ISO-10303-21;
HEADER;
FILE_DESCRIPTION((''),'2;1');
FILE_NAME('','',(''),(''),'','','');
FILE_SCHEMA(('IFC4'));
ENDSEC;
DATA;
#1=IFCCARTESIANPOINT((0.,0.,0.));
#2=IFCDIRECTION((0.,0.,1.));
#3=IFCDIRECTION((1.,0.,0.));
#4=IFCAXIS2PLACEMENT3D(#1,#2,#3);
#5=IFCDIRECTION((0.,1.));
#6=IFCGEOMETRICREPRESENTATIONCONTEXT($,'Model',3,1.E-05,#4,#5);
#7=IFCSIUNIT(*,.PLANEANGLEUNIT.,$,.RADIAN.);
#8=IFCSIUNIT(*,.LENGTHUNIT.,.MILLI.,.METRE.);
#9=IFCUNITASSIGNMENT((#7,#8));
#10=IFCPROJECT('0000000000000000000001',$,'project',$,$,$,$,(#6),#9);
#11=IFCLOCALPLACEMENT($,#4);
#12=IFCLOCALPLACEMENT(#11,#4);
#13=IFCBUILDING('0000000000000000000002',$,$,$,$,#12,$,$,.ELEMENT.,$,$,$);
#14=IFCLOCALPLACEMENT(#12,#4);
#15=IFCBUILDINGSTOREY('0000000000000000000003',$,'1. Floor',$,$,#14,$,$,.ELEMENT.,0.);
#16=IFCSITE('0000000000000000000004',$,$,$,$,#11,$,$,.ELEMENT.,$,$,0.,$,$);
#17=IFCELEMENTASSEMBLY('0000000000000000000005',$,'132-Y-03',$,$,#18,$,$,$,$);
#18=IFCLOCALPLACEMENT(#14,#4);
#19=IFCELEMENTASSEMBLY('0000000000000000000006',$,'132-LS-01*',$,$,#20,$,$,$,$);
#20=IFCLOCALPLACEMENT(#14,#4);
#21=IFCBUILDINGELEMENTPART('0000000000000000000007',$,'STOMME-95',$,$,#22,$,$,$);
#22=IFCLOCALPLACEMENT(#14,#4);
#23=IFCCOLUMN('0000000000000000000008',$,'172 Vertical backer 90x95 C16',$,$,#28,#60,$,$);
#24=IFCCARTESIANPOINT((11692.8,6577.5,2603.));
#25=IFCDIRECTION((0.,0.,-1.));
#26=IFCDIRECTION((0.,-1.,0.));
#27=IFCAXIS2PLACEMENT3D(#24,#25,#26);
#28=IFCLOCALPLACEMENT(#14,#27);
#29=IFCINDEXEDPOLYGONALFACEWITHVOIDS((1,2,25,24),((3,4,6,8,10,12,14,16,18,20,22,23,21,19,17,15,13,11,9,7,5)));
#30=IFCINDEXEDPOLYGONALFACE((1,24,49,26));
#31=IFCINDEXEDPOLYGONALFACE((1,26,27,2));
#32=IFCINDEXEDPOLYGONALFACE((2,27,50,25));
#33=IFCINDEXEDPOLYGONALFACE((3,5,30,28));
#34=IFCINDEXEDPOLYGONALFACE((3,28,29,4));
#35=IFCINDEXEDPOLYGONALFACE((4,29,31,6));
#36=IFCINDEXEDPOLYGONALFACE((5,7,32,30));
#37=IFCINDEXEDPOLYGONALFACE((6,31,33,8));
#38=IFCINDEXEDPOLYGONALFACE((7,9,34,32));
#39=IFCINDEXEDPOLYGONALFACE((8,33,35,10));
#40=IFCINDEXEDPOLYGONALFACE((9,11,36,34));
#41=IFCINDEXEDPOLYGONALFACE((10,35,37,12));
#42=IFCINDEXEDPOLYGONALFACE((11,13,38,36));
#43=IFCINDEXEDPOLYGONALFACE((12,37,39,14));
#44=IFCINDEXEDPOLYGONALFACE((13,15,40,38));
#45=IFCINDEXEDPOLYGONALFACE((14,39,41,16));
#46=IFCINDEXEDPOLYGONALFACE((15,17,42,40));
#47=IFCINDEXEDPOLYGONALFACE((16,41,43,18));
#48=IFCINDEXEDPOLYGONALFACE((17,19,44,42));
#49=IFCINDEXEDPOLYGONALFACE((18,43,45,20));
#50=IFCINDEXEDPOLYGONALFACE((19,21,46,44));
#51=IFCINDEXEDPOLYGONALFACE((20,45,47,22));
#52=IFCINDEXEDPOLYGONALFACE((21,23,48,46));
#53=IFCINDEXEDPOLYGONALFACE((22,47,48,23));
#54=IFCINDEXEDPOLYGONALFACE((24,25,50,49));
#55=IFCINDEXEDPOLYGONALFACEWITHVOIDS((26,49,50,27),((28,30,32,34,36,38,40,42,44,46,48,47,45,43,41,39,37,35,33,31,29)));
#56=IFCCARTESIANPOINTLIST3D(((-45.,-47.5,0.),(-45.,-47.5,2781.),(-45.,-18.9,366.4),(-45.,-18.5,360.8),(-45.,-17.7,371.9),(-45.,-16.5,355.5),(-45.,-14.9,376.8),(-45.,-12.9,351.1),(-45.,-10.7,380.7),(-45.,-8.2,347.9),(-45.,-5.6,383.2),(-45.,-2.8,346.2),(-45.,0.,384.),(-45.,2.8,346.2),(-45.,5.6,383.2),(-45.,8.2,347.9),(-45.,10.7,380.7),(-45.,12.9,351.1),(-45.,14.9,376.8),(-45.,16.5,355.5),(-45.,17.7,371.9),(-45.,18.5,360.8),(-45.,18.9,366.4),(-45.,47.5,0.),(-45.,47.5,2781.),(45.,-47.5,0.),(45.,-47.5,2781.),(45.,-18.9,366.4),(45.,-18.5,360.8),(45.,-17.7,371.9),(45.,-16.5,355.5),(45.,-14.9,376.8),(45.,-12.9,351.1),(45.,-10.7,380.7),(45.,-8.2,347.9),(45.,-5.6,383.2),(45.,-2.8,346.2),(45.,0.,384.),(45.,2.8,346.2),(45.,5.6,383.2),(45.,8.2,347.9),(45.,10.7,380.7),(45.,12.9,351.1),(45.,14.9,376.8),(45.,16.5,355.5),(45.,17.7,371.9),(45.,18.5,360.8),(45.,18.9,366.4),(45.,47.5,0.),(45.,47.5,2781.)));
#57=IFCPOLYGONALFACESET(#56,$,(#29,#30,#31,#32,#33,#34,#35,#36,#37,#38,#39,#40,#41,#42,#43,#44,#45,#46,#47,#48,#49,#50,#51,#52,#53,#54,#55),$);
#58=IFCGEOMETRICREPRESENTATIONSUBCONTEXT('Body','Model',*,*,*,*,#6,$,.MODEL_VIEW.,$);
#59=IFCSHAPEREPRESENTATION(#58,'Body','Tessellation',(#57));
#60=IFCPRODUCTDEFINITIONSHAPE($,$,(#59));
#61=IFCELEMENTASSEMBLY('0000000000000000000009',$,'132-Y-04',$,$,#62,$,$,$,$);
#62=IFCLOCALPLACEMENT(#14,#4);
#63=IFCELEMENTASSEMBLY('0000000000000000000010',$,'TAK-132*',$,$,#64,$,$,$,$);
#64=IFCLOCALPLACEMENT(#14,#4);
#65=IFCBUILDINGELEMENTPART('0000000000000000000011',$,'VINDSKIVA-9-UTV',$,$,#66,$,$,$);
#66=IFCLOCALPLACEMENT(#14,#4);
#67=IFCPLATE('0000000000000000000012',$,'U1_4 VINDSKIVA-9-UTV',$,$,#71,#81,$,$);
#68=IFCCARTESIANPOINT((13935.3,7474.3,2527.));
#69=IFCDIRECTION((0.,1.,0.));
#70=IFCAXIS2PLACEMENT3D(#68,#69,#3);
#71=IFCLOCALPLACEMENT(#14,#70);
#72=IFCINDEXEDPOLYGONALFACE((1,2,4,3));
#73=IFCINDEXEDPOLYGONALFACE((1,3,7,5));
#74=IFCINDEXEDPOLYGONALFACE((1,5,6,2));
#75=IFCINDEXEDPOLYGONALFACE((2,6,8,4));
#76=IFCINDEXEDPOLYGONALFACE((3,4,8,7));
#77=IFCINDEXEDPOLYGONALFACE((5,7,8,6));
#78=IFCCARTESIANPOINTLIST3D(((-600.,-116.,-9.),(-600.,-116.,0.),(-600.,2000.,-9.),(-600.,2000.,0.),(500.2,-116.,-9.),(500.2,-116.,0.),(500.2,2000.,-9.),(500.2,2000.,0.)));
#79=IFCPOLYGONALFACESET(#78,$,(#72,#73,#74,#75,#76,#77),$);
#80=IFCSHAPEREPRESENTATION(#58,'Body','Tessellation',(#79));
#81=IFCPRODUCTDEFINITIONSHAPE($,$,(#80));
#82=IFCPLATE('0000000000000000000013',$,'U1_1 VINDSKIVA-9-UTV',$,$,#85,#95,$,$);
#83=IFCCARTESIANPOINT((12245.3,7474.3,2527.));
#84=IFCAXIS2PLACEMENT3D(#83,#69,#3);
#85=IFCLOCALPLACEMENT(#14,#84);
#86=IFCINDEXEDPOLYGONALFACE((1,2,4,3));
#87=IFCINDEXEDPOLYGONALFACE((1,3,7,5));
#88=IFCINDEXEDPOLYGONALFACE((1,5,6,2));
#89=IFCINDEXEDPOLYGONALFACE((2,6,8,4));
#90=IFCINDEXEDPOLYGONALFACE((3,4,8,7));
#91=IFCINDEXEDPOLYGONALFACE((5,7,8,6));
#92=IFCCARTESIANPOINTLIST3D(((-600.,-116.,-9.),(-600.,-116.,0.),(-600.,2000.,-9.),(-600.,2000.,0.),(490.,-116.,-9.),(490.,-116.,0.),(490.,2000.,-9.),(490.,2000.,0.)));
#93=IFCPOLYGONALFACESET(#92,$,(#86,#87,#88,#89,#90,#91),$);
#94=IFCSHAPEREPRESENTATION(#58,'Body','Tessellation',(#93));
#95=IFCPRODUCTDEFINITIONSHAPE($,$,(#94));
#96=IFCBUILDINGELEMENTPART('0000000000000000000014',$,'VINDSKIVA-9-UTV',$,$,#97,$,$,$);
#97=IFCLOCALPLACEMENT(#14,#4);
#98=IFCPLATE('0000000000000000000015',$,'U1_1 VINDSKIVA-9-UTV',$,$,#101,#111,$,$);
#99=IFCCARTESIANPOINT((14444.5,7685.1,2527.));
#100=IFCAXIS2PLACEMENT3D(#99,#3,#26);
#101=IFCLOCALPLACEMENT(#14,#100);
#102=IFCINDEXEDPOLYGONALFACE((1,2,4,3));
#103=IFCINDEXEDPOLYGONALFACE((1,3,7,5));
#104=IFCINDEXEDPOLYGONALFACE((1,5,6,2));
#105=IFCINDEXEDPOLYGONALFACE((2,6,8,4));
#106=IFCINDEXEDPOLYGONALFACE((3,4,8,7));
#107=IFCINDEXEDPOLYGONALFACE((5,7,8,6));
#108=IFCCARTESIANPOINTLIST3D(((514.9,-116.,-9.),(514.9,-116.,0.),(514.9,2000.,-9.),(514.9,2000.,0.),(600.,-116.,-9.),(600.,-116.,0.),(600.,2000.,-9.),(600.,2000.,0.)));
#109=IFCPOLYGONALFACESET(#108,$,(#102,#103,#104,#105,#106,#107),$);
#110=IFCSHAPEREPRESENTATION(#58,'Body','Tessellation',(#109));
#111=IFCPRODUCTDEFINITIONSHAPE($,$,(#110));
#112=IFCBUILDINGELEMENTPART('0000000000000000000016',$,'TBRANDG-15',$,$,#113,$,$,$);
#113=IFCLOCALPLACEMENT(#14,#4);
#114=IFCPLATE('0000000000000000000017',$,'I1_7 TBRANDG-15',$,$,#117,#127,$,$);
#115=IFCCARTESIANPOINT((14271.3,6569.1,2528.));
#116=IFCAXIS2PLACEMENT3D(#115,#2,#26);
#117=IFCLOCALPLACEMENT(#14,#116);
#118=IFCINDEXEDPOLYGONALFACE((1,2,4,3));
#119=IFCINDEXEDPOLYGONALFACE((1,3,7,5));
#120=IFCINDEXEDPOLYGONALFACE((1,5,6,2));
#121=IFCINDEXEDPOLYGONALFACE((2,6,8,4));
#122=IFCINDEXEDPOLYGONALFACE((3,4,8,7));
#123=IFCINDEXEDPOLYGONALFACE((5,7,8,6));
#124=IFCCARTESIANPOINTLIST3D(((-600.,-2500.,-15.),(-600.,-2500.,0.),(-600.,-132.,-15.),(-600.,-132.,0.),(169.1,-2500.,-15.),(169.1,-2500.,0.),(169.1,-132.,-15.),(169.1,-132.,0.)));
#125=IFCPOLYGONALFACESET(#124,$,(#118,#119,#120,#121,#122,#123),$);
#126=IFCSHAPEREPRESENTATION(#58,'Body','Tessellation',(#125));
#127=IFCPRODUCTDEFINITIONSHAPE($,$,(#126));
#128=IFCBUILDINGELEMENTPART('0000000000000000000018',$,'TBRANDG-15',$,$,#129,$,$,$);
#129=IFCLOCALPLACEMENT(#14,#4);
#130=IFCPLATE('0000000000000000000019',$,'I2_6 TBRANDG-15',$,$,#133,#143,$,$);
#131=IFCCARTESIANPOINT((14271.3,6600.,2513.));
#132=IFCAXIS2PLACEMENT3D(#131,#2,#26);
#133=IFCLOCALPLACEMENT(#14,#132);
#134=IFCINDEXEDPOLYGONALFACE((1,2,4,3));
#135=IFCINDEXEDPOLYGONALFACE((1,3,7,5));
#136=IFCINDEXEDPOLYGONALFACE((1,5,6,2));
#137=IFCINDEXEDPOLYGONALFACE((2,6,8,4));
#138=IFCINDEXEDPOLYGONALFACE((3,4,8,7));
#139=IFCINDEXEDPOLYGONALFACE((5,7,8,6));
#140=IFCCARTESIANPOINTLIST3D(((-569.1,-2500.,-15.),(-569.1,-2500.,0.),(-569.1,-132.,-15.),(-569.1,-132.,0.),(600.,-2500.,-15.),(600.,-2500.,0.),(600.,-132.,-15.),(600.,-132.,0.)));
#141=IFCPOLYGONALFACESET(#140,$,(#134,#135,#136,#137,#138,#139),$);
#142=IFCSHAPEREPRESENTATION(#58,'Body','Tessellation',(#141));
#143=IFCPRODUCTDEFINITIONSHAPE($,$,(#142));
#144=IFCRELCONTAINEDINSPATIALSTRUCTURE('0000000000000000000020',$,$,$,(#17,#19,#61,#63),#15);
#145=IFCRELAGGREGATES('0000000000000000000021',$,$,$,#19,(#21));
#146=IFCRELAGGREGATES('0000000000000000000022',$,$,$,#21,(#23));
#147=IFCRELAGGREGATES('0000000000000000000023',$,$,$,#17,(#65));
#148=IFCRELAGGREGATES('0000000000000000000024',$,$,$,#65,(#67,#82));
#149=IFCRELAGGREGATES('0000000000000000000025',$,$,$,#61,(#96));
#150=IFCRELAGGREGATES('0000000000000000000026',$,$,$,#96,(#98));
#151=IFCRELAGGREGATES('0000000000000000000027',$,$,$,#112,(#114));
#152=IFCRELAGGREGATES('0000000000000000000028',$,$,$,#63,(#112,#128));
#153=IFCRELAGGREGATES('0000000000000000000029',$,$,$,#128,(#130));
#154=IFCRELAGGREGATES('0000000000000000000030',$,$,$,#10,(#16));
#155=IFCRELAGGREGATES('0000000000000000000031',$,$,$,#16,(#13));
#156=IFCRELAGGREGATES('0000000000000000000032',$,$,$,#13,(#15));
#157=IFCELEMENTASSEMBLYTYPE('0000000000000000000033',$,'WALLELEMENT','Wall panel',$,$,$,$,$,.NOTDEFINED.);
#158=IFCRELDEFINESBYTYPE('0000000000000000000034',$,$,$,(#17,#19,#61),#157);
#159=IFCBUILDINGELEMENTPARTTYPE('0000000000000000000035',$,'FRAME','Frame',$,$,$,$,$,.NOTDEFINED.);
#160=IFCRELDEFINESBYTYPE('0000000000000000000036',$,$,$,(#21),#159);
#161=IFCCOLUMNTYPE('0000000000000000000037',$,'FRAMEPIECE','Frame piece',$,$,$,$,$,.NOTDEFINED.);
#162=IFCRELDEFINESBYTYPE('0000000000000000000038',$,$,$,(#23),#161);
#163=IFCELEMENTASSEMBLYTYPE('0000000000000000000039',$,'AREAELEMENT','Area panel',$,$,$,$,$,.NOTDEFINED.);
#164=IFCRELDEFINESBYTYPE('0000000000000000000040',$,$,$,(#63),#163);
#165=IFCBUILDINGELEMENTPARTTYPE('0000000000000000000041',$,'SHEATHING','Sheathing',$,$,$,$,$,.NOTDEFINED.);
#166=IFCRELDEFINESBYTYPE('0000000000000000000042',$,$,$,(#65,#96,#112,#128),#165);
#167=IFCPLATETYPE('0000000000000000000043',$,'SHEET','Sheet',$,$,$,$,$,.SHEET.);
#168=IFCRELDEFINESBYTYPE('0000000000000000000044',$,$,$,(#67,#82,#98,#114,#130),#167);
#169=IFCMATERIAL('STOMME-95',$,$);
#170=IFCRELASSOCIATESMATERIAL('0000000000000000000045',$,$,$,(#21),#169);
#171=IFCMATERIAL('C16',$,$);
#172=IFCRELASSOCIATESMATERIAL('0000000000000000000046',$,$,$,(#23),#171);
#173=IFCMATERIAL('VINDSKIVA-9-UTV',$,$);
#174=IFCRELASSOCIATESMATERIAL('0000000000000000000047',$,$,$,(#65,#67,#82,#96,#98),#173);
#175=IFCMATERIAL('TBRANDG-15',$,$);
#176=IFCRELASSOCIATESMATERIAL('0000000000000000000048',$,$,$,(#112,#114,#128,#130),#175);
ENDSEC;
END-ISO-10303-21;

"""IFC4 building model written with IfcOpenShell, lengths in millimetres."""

from ifc_helpers import new_model, si_unit, direction, frame, origin_with_axes, origin_2d_with_axis, place, context, subcontext, project, spatial, rectangle, circle, extrude, boolean, material, type_object, element, aggregate, save


model = new_model("IFC4")

# Units and contexts
model_context = context("Model", 3, precision=1e-05, world=origin_with_axes(), true_north=direction((0.0, 1.0)))
body_context = subcontext(model_context, "Body", "Model", "MODEL_VIEW")
ifc_project = project(units=[si_unit("PLANEANGLEUNIT", "RADIAN"), si_unit("LENGTHUNIT", "METRE", prefix="MILLI")], contexts=[model_context])

# Site, building, storey
site_placement = place(None, origin_with_axes())
site = spatial("IfcSite", under=ifc_project, at=site_placement, CompositionType="ELEMENT", RefElevation=0.0)
building_placement = place(site_placement, origin_with_axes())
building = spatial("IfcBuilding", under=site, at=building_placement, CompositionType="ELEMENT")
storey_placement = place(building_placement, origin_with_axes())
storey = spatial("IfcBuildingStorey", under=building, at=storey_placement, Name="1. Floor", CompositionType="ELEMENT", Elevation=0.0)

# Element assembly
element_assembly_type_1 = type_object("IfcElementAssemblyType", Name="WALLELEMENT", Description="Wall panel", PredefinedType="NOTDEFINED")
assembly_1_placement = place(storey_placement, origin_with_axes())
assembly_1 = element("IfcElementAssembly", 1, at=assembly_1_placement, inside=storey, type_object=element_assembly_type_1, Name="132-Y-03")
building_element_part_type_1 = type_object("IfcBuildingElementPartType", Name="FRAME", Description="Frame", PredefinedType="NOTDEFINED")
column_type = type_object("IfcColumnType", Name="FRAMEPIECE", Description="Frame piece", PredefinedType="NOTDEFINED")

# Element assemblies, building element part, column
assembly_2_placement = place(storey_placement, origin_with_axes())
assembly_2 = element("IfcElementAssembly", 2, at=assembly_2_placement, inside=storey, type_object=element_assembly_type_1, Name="132-LS-01*")
ifc_material_1 = material(Name="STOMME-95")
building_element_part_1_placement = place(storey_placement, origin_with_axes())
building_element_part_1 = element("IfcBuildingElementPart", 3, at=building_element_part_1_placement, type_object=building_element_part_type_1, material=ifc_material_1, Name="STOMME-95")
aggregate(assembly_2, [building_element_part_1])
ifc_material_2 = material(Name="C16")
column_1_placement = place(storey_placement, frame((11692.8, 6577.5, 2603.0), z_axis=(0.0, 0.0, -1.0), x_axis=(0.0, -1.0, 0.0)))
column_1 = element("IfcColumn", 4, at=column_1_placement, type_object=column_type, material=ifc_material_2, Name="172 Vertical backer 90x95 C16", context=body_context, shape_type="CSG", body=[
    boolean("DIFFERENCE", boolean("DIFFERENCE", extrude(rectangle(XDim=90.0, YDim=95.0, at=origin_2d_with_axis()), origin_with_axes(), (0.0, 0.0, 1.0), 2781.0), extrude(circle(Radius=19.0, at=origin_2d_with_axis()), frame((90.0, 0.0, 365.0), z_axis=(1.0, 0.0, 0.0), x_axis=(0.0, 0.0, 1.0)), (0.0, 0.0, -1.0), 180.0)), extrude(circle(Radius=19.0, at=origin_2d_with_axis()), frame((-90.0, 0.0, 365.0), z_axis=(-1.0, 0.0, 0.0), x_axis=(0.0, 0.0, 1.0)), (0.0, 0.0, -1.0), 180.0)),
])
aggregate(building_element_part_1, [column_1])
assembly_3_placement = place(storey_placement, origin_with_axes())
assembly_3 = element("IfcElementAssembly", 5, at=assembly_3_placement, inside=storey, type_object=element_assembly_type_1, Name="132-Y-04")

# Element assembly
element_assembly_type_2 = type_object("IfcElementAssemblyType", Name="AREAELEMENT", Description="Area panel", PredefinedType="NOTDEFINED")
assembly_4_placement = place(storey_placement, origin_with_axes())
assembly_4 = element("IfcElementAssembly", 6, at=assembly_4_placement, inside=storey, type_object=element_assembly_type_2, Name="TAK-132*")

# Building element part
ifc_material_3 = material(Name="VINDSKIVA-9-UTV")
building_element_part_type_2 = type_object("IfcBuildingElementPartType", Name="SHEATHING", Description="Sheathing", PredefinedType="NOTDEFINED")
building_element_part_2_placement = place(storey_placement, origin_with_axes())
building_element_part_2 = element("IfcBuildingElementPart", 7, at=building_element_part_2_placement, type_object=building_element_part_type_2, material=ifc_material_3, Name="VINDSKIVA-9-UTV")
aggregate(assembly_1, [building_element_part_2])

# Plates
plate_type_1 = type_object("IfcPlateType", Name="SHEET", Description="Sheet", PredefinedType="SHEET")
plate_1_placement = place(storey_placement, frame((13935.3, 7474.3, 2527.0), z_axis=(0.0, 1.0, 0.0), x_axis=(1.0, 0.0, 0.0)))
plate_1 = element("IfcPlate", 8, at=plate_1_placement, type_object=plate_type_1, material=ifc_material_3, Name="U1_4 VINDSKIVA-9-UTV", context=body_context, shape_type="SweptSolid", body=[
    extrude(rectangle(XDim=9.0, YDim=1100.2, at=origin_2d_with_axis()), frame((-49.9, -116.0, -4.5), z_axis=(0.0, 1.0, 0.0), x_axis=(0.0, 0.0, 1.0)), (0.0, 0.0, 1.0), 2116.0),
])
plate_2_placement = place(storey_placement, frame((12245.3, 7474.3, 2527.0), z_axis=(0.0, 1.0, 0.0), x_axis=(1.0, 0.0, 0.0)))
plate_2 = element("IfcPlate", 9, at=plate_2_placement, type_object=plate_type_1, material=ifc_material_3, Name="U1_1 VINDSKIVA-9-UTV", context=body_context, shape_type="SweptSolid", body=[
    extrude(rectangle(XDim=9.0, YDim=1090.0, at=origin_2d_with_axis()), frame((-55.0, -116.0, -4.5), z_axis=(0.0, 1.0, 0.0), x_axis=(0.0, 0.0, 1.0)), (0.0, 0.0, 1.0), 2116.0),
])
aggregate(building_element_part_2, [plate_1, plate_2])

# Building element part
building_element_part_3_placement = place(storey_placement, origin_with_axes())
building_element_part_3 = element("IfcBuildingElementPart", 10, at=building_element_part_3_placement, type_object=building_element_part_type_2, material=ifc_material_3, Name="VINDSKIVA-9-UTV")
aggregate(assembly_3, [building_element_part_3])

# Plate
plate_3_placement = place(storey_placement, frame((14444.5, 7685.1, 2527.0), z_axis=(1.0, 0.0, 0.0), x_axis=(0.0, -1.0, 0.0)))
plate_3 = element("IfcPlate", 11, at=plate_3_placement, type_object=plate_type_1, material=ifc_material_3, Name="U1_1 VINDSKIVA-9-UTV", context=body_context, shape_type="SweptSolid", body=[
    extrude(rectangle(XDim=9.0, YDim=85.1, at=origin_2d_with_axis()), frame((557.5, -116.0, -4.5), z_axis=(0.0, 1.0, 0.0), x_axis=(0.0, 0.0, 1.0)), (0.0, 0.0, 1.0), 2116.0),
])
aggregate(building_element_part_3, [plate_3])

# Building element part, plate
ifc_material_4 = material(Name="TBRANDG-15")
building_element_part_4_placement = place(storey_placement, origin_with_axes())
building_element_part_4 = element("IfcBuildingElementPart", 12, at=building_element_part_4_placement, type_object=building_element_part_type_2, material=ifc_material_4, Name="TBRANDG-15")
plate_4_placement = place(storey_placement, frame((14271.3, 6569.1, 2528.0), z_axis=(0.0, 0.0, 1.0), x_axis=(0.0, -1.0, 0.0)))
plate_4 = element("IfcPlate", 13, at=plate_4_placement, type_object=plate_type_1, material=ifc_material_4, Name="I1_7 TBRANDG-15", context=body_context, shape_type="SweptSolid", body=[
    extrude(rectangle(XDim=15.0, YDim=769.1, at=origin_2d_with_axis()), frame((-215.4, -2500.0, -7.5), z_axis=(0.0, 1.0, 0.0), x_axis=(0.0, 0.0, 1.0)), (0.0, 0.0, 1.0), 2368.0),
])
aggregate(building_element_part_4, [plate_4])

# Building element part
building_element_part_5_placement = place(storey_placement, origin_with_axes())
building_element_part_5 = element("IfcBuildingElementPart", 14, at=building_element_part_5_placement, type_object=building_element_part_type_2, material=ifc_material_4, Name="TBRANDG-15")
aggregate(assembly_4, [building_element_part_4, building_element_part_5])

# Plate
plate_5_placement = place(storey_placement, frame((14271.3, 6600.0, 2513.0), z_axis=(0.0, 0.0, 1.0), x_axis=(0.0, -1.0, 0.0)))
plate_5 = element("IfcPlate", 15, at=plate_5_placement, type_object=plate_type_1, material=ifc_material_4, Name="I2_6 TBRANDG-15", context=body_context, shape_type="SweptSolid", body=[
    extrude(rectangle(XDim=15.0, YDim=1169.1, at=origin_2d_with_axis()), frame((15.4, -2500.0, -7.5), z_axis=(0.0, 1.0, 0.0), x_axis=(0.0, 0.0, 1.0)), (0.0, 0.0, 1.0), 2368.0),
])
aggregate(building_element_part_5, [plate_5])

save(model, "model.ifc")
